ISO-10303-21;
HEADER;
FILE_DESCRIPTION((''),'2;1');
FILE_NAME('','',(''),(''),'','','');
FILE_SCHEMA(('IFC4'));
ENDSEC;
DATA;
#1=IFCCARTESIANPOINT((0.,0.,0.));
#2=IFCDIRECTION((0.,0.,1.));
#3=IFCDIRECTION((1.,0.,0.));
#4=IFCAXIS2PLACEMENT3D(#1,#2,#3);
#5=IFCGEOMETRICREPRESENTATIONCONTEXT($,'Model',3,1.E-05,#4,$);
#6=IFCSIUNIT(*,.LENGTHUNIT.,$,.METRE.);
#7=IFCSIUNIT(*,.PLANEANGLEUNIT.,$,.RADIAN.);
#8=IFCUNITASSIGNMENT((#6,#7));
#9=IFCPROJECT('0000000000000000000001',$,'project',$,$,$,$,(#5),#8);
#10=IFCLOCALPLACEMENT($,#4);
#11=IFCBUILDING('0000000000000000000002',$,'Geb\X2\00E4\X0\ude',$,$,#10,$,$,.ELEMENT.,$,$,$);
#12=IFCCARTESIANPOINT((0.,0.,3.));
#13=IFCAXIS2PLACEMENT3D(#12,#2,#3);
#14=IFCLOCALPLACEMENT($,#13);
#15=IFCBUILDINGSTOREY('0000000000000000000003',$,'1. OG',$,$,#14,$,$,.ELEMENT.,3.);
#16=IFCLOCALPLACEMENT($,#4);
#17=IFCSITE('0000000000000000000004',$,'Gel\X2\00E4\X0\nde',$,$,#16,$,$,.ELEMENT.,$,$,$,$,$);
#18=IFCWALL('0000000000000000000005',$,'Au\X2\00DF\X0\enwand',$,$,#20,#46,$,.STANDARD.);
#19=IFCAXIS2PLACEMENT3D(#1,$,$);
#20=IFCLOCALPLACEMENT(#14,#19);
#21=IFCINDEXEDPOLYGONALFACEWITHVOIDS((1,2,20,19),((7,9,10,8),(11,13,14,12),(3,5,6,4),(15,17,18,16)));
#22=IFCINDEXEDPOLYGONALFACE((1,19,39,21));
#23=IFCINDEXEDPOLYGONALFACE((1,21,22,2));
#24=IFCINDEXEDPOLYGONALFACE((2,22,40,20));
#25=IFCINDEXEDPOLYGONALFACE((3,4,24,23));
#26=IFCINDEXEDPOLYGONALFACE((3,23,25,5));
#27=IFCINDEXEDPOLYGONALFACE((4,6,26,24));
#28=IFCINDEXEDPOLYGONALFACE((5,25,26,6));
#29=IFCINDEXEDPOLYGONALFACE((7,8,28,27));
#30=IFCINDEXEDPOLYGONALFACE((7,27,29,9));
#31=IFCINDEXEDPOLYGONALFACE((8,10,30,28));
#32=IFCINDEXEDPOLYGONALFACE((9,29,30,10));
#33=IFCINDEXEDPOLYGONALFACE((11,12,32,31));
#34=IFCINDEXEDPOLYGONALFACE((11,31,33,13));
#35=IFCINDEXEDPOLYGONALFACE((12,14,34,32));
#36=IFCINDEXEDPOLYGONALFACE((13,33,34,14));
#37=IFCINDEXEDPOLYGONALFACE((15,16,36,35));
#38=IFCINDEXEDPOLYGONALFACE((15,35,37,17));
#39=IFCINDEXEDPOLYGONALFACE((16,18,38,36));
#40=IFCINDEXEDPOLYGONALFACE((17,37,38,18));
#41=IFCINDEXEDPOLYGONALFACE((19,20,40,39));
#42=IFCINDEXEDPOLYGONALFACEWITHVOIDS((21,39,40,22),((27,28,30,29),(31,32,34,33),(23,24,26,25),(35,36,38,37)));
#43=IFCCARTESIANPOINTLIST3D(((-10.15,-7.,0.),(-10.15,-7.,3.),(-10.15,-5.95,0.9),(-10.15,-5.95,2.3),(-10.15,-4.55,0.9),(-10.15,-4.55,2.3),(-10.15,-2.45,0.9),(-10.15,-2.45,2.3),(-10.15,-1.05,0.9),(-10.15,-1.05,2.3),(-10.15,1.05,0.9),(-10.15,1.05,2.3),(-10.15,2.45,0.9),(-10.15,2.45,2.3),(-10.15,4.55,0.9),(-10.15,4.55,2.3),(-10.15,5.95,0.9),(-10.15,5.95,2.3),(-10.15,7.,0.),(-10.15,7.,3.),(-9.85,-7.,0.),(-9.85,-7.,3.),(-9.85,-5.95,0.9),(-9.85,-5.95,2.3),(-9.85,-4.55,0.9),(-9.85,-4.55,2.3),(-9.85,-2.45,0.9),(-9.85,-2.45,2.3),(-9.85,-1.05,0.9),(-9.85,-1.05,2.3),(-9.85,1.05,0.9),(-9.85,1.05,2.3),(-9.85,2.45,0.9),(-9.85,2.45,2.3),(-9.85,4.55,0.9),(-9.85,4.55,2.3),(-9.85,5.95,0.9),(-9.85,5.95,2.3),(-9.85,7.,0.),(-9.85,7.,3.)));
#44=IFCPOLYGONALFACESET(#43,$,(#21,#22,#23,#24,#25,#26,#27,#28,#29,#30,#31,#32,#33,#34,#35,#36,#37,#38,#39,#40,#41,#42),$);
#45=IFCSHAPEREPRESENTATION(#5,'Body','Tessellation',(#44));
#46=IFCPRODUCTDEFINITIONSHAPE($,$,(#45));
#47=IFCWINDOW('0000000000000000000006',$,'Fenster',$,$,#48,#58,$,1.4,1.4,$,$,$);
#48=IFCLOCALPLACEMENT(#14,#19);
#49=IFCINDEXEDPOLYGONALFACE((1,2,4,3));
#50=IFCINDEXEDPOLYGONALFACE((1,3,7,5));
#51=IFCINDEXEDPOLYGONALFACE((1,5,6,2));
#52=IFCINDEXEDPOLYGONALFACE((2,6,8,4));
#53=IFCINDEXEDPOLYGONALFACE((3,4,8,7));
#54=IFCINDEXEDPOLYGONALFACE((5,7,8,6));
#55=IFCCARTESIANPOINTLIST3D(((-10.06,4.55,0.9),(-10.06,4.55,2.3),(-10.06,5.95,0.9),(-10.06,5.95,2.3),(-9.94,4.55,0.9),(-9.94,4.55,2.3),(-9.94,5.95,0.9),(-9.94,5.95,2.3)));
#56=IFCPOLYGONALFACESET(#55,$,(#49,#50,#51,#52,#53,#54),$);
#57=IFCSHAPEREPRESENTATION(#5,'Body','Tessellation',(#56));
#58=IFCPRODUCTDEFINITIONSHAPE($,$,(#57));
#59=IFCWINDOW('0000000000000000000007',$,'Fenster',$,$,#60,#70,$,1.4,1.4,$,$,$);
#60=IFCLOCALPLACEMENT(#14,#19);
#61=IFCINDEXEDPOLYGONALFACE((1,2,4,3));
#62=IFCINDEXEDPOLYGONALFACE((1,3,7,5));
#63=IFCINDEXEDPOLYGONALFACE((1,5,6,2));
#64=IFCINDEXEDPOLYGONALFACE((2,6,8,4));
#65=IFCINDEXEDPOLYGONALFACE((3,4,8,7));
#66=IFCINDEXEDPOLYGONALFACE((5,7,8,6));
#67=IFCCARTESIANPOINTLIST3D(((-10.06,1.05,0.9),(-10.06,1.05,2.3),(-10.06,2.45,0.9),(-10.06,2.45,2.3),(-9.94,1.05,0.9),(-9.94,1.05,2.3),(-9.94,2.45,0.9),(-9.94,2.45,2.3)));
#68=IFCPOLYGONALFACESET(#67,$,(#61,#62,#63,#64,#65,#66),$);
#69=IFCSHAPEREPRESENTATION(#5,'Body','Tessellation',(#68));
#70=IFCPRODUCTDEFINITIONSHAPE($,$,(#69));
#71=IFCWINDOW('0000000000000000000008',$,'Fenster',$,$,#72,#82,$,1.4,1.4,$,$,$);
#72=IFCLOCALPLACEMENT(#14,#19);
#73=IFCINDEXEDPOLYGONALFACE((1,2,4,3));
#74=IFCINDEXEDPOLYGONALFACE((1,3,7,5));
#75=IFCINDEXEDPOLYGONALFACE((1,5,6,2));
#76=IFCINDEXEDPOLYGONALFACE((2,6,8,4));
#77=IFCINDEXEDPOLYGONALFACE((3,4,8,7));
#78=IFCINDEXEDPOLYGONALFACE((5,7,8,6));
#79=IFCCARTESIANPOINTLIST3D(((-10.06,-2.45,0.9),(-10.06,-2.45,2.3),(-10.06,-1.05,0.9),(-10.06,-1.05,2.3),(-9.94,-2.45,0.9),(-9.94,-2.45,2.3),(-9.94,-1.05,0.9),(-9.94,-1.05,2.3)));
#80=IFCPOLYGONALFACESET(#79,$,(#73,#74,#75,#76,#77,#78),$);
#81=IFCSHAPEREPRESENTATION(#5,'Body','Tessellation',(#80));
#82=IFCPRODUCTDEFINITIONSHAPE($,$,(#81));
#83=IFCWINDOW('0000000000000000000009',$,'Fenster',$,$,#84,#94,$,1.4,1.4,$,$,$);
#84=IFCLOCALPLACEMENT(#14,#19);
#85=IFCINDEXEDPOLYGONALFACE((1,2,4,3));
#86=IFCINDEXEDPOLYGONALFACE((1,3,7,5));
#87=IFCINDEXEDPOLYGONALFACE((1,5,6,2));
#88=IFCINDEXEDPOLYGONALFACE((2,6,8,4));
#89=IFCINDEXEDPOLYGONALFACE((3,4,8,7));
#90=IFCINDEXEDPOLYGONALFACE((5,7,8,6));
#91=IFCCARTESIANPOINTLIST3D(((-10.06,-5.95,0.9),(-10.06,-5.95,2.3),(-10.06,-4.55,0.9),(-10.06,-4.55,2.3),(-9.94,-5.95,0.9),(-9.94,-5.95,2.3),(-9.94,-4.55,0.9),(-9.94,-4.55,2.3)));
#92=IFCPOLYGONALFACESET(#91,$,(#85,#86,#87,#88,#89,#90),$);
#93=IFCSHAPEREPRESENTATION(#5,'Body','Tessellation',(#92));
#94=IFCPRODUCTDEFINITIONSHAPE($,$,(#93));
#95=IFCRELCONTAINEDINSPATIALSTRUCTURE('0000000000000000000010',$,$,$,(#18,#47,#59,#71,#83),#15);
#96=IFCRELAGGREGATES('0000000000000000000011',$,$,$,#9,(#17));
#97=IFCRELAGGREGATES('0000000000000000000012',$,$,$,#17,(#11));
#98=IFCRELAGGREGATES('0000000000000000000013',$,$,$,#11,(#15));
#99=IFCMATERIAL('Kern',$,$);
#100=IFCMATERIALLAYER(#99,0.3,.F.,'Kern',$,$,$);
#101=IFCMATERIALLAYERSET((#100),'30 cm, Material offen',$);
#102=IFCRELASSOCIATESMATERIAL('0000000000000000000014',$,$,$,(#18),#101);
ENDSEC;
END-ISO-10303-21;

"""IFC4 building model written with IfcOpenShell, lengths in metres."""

from ifc_helpers import new_model, si_unit, frame, origin_with_axes, origin_2d, place, context, project, spatial, rectangle, extrude, material, layer, layer_set, element, fill, save


model = new_model("IFC4")

# Units and contexts
model_context = context("Model", 3, precision=1e-05, world=origin_with_axes())
ifc_project = project(units=[si_unit("LENGTHUNIT", "METRE"), si_unit("PLANEANGLEUNIT", "RADIAN")], contexts=[model_context])

# Site, building, storey
site_placement = place(None, origin_with_axes())
site = spatial("IfcSite", under=ifc_project, at=site_placement, Name="Gelände", CompositionType="ELEMENT")
building_placement = place(None, origin_with_axes())
building = spatial("IfcBuilding", under=site, at=building_placement, Name="Gebäude", CompositionType="ELEMENT")
storey_placement = place(None, frame((0.0, 0.0, 3.0), z_axis=(0.0, 0.0, 1.0), x_axis=(1.0, 0.0, 0.0)))
storey = spatial("IfcBuildingStorey", under=building, at=storey_placement, Name="1. OG", CompositionType="ELEMENT", Elevation=3.0)

# Wall, openings, windows
ifc_material = material(Name="Kern")
ifc_layer = layer(ifc_material, 0.3, ventilated=False, Name="Kern")
ifc_layer_set = layer_set([ifc_layer], Name="30 cm, Material offen")
wall_1_placement = place(None, frame((-10.0, 0.0, 3.0), z_axis=(0.0, 0.0, 1.0), x_axis=(0.0, -1.0, 0.0)))
wall_1 = element("IfcWall", 1, at=wall_1_placement, inside=storey, material=ifc_layer_set, Name="Außenwand", PredefinedType="STANDARD", context=model_context, shape_type="SweptSolid", body=[
    extrude(rectangle(XDim=14.0, YDim=0.3, at=origin_2d()), origin_with_axes(), (0.0, 0.0, 1.0), 3.0),
])
opening_1_placement = place(wall_1_placement, frame((-5.25, 0.0, 0.9), z_axis=(0.0, 0.0, 1.0), x_axis=(1.0, 0.0, 0.0)))
opening_1 = element("IfcOpeningElement", 2, at=opening_1_placement, cuts=wall_1, PredefinedType="OPENING", context=model_context, shape_type="SweptSolid", body=[
    extrude(rectangle(XDim=1.4, YDim=0.34, at=origin_2d()), origin_with_axes(), (0.0, 0.0, 1.0), 1.4),
])
opening_2_placement = place(wall_1_placement, frame((-1.75, 0.0, 0.9), z_axis=(0.0, 0.0, 1.0), x_axis=(1.0, 0.0, 0.0)))
opening_2 = element("IfcOpeningElement", 3, at=opening_2_placement, cuts=wall_1, PredefinedType="OPENING", context=model_context, shape_type="SweptSolid", body=[
    extrude(rectangle(XDim=1.4, YDim=0.34, at=origin_2d()), origin_with_axes(), (0.0, 0.0, 1.0), 1.4),
])
opening_3_placement = place(wall_1_placement, frame((1.75, 0.0, 0.9), z_axis=(0.0, 0.0, 1.0), x_axis=(1.0, 0.0, 0.0)))
opening_3 = element("IfcOpeningElement", 4, at=opening_3_placement, cuts=wall_1, PredefinedType="OPENING", context=model_context, shape_type="SweptSolid", body=[
    extrude(rectangle(XDim=1.4, YDim=0.34, at=origin_2d()), origin_with_axes(), (0.0, 0.0, 1.0), 1.4),
])
opening_4_placement = place(wall_1_placement, frame((5.25, 0.0, 0.9), z_axis=(0.0, 0.0, 1.0), x_axis=(1.0, 0.0, 0.0)))
opening_4 = element("IfcOpeningElement", 5, at=opening_4_placement, cuts=wall_1, PredefinedType="OPENING", context=model_context, shape_type="SweptSolid", body=[
    extrude(rectangle(XDim=1.4, YDim=0.34, at=origin_2d()), origin_with_axes(), (0.0, 0.0, 1.0), 1.4),
])
window_1_placement = place(opening_1_placement, origin_with_axes())
window_1 = element("IfcWindow", 6, at=window_1_placement, inside=storey, Name="Fenster", OverallHeight=1.4, OverallWidth=1.4, context=model_context, shape_type="SweptSolid", body=[
    extrude(rectangle(XDim=1.4, YDim=0.12, at=origin_2d()), origin_with_axes(), (0.0, 0.0, 1.0), 1.4),
])
fill(opening_1, window_1)
window_2_placement = place(opening_2_placement, origin_with_axes())
window_2 = element("IfcWindow", 7, at=window_2_placement, inside=storey, Name="Fenster", OverallHeight=1.4, OverallWidth=1.4, context=model_context, shape_type="SweptSolid", body=[
    extrude(rectangle(XDim=1.4, YDim=0.12, at=origin_2d()), origin_with_axes(), (0.0, 0.0, 1.0), 1.4),
])
fill(opening_2, window_2)
window_3_placement = place(opening_3_placement, origin_with_axes())
window_3 = element("IfcWindow", 8, at=window_3_placement, inside=storey, Name="Fenster", OverallHeight=1.4, OverallWidth=1.4, context=model_context, shape_type="SweptSolid", body=[
    extrude(rectangle(XDim=1.4, YDim=0.12, at=origin_2d()), origin_with_axes(), (0.0, 0.0, 1.0), 1.4),
])
fill(opening_3, window_3)
window_4_placement = place(opening_4_placement, origin_with_axes())
window_4 = element("IfcWindow", 9, at=window_4_placement, inside=storey, Name="Fenster", OverallHeight=1.4, OverallWidth=1.4, context=model_context, shape_type="SweptSolid", body=[
    extrude(rectangle(XDim=1.4, YDim=0.12, at=origin_2d()), origin_with_axes(), (0.0, 0.0, 1.0), 1.4),
])
fill(opening_4, window_4)

save(model, "model.ifc")
